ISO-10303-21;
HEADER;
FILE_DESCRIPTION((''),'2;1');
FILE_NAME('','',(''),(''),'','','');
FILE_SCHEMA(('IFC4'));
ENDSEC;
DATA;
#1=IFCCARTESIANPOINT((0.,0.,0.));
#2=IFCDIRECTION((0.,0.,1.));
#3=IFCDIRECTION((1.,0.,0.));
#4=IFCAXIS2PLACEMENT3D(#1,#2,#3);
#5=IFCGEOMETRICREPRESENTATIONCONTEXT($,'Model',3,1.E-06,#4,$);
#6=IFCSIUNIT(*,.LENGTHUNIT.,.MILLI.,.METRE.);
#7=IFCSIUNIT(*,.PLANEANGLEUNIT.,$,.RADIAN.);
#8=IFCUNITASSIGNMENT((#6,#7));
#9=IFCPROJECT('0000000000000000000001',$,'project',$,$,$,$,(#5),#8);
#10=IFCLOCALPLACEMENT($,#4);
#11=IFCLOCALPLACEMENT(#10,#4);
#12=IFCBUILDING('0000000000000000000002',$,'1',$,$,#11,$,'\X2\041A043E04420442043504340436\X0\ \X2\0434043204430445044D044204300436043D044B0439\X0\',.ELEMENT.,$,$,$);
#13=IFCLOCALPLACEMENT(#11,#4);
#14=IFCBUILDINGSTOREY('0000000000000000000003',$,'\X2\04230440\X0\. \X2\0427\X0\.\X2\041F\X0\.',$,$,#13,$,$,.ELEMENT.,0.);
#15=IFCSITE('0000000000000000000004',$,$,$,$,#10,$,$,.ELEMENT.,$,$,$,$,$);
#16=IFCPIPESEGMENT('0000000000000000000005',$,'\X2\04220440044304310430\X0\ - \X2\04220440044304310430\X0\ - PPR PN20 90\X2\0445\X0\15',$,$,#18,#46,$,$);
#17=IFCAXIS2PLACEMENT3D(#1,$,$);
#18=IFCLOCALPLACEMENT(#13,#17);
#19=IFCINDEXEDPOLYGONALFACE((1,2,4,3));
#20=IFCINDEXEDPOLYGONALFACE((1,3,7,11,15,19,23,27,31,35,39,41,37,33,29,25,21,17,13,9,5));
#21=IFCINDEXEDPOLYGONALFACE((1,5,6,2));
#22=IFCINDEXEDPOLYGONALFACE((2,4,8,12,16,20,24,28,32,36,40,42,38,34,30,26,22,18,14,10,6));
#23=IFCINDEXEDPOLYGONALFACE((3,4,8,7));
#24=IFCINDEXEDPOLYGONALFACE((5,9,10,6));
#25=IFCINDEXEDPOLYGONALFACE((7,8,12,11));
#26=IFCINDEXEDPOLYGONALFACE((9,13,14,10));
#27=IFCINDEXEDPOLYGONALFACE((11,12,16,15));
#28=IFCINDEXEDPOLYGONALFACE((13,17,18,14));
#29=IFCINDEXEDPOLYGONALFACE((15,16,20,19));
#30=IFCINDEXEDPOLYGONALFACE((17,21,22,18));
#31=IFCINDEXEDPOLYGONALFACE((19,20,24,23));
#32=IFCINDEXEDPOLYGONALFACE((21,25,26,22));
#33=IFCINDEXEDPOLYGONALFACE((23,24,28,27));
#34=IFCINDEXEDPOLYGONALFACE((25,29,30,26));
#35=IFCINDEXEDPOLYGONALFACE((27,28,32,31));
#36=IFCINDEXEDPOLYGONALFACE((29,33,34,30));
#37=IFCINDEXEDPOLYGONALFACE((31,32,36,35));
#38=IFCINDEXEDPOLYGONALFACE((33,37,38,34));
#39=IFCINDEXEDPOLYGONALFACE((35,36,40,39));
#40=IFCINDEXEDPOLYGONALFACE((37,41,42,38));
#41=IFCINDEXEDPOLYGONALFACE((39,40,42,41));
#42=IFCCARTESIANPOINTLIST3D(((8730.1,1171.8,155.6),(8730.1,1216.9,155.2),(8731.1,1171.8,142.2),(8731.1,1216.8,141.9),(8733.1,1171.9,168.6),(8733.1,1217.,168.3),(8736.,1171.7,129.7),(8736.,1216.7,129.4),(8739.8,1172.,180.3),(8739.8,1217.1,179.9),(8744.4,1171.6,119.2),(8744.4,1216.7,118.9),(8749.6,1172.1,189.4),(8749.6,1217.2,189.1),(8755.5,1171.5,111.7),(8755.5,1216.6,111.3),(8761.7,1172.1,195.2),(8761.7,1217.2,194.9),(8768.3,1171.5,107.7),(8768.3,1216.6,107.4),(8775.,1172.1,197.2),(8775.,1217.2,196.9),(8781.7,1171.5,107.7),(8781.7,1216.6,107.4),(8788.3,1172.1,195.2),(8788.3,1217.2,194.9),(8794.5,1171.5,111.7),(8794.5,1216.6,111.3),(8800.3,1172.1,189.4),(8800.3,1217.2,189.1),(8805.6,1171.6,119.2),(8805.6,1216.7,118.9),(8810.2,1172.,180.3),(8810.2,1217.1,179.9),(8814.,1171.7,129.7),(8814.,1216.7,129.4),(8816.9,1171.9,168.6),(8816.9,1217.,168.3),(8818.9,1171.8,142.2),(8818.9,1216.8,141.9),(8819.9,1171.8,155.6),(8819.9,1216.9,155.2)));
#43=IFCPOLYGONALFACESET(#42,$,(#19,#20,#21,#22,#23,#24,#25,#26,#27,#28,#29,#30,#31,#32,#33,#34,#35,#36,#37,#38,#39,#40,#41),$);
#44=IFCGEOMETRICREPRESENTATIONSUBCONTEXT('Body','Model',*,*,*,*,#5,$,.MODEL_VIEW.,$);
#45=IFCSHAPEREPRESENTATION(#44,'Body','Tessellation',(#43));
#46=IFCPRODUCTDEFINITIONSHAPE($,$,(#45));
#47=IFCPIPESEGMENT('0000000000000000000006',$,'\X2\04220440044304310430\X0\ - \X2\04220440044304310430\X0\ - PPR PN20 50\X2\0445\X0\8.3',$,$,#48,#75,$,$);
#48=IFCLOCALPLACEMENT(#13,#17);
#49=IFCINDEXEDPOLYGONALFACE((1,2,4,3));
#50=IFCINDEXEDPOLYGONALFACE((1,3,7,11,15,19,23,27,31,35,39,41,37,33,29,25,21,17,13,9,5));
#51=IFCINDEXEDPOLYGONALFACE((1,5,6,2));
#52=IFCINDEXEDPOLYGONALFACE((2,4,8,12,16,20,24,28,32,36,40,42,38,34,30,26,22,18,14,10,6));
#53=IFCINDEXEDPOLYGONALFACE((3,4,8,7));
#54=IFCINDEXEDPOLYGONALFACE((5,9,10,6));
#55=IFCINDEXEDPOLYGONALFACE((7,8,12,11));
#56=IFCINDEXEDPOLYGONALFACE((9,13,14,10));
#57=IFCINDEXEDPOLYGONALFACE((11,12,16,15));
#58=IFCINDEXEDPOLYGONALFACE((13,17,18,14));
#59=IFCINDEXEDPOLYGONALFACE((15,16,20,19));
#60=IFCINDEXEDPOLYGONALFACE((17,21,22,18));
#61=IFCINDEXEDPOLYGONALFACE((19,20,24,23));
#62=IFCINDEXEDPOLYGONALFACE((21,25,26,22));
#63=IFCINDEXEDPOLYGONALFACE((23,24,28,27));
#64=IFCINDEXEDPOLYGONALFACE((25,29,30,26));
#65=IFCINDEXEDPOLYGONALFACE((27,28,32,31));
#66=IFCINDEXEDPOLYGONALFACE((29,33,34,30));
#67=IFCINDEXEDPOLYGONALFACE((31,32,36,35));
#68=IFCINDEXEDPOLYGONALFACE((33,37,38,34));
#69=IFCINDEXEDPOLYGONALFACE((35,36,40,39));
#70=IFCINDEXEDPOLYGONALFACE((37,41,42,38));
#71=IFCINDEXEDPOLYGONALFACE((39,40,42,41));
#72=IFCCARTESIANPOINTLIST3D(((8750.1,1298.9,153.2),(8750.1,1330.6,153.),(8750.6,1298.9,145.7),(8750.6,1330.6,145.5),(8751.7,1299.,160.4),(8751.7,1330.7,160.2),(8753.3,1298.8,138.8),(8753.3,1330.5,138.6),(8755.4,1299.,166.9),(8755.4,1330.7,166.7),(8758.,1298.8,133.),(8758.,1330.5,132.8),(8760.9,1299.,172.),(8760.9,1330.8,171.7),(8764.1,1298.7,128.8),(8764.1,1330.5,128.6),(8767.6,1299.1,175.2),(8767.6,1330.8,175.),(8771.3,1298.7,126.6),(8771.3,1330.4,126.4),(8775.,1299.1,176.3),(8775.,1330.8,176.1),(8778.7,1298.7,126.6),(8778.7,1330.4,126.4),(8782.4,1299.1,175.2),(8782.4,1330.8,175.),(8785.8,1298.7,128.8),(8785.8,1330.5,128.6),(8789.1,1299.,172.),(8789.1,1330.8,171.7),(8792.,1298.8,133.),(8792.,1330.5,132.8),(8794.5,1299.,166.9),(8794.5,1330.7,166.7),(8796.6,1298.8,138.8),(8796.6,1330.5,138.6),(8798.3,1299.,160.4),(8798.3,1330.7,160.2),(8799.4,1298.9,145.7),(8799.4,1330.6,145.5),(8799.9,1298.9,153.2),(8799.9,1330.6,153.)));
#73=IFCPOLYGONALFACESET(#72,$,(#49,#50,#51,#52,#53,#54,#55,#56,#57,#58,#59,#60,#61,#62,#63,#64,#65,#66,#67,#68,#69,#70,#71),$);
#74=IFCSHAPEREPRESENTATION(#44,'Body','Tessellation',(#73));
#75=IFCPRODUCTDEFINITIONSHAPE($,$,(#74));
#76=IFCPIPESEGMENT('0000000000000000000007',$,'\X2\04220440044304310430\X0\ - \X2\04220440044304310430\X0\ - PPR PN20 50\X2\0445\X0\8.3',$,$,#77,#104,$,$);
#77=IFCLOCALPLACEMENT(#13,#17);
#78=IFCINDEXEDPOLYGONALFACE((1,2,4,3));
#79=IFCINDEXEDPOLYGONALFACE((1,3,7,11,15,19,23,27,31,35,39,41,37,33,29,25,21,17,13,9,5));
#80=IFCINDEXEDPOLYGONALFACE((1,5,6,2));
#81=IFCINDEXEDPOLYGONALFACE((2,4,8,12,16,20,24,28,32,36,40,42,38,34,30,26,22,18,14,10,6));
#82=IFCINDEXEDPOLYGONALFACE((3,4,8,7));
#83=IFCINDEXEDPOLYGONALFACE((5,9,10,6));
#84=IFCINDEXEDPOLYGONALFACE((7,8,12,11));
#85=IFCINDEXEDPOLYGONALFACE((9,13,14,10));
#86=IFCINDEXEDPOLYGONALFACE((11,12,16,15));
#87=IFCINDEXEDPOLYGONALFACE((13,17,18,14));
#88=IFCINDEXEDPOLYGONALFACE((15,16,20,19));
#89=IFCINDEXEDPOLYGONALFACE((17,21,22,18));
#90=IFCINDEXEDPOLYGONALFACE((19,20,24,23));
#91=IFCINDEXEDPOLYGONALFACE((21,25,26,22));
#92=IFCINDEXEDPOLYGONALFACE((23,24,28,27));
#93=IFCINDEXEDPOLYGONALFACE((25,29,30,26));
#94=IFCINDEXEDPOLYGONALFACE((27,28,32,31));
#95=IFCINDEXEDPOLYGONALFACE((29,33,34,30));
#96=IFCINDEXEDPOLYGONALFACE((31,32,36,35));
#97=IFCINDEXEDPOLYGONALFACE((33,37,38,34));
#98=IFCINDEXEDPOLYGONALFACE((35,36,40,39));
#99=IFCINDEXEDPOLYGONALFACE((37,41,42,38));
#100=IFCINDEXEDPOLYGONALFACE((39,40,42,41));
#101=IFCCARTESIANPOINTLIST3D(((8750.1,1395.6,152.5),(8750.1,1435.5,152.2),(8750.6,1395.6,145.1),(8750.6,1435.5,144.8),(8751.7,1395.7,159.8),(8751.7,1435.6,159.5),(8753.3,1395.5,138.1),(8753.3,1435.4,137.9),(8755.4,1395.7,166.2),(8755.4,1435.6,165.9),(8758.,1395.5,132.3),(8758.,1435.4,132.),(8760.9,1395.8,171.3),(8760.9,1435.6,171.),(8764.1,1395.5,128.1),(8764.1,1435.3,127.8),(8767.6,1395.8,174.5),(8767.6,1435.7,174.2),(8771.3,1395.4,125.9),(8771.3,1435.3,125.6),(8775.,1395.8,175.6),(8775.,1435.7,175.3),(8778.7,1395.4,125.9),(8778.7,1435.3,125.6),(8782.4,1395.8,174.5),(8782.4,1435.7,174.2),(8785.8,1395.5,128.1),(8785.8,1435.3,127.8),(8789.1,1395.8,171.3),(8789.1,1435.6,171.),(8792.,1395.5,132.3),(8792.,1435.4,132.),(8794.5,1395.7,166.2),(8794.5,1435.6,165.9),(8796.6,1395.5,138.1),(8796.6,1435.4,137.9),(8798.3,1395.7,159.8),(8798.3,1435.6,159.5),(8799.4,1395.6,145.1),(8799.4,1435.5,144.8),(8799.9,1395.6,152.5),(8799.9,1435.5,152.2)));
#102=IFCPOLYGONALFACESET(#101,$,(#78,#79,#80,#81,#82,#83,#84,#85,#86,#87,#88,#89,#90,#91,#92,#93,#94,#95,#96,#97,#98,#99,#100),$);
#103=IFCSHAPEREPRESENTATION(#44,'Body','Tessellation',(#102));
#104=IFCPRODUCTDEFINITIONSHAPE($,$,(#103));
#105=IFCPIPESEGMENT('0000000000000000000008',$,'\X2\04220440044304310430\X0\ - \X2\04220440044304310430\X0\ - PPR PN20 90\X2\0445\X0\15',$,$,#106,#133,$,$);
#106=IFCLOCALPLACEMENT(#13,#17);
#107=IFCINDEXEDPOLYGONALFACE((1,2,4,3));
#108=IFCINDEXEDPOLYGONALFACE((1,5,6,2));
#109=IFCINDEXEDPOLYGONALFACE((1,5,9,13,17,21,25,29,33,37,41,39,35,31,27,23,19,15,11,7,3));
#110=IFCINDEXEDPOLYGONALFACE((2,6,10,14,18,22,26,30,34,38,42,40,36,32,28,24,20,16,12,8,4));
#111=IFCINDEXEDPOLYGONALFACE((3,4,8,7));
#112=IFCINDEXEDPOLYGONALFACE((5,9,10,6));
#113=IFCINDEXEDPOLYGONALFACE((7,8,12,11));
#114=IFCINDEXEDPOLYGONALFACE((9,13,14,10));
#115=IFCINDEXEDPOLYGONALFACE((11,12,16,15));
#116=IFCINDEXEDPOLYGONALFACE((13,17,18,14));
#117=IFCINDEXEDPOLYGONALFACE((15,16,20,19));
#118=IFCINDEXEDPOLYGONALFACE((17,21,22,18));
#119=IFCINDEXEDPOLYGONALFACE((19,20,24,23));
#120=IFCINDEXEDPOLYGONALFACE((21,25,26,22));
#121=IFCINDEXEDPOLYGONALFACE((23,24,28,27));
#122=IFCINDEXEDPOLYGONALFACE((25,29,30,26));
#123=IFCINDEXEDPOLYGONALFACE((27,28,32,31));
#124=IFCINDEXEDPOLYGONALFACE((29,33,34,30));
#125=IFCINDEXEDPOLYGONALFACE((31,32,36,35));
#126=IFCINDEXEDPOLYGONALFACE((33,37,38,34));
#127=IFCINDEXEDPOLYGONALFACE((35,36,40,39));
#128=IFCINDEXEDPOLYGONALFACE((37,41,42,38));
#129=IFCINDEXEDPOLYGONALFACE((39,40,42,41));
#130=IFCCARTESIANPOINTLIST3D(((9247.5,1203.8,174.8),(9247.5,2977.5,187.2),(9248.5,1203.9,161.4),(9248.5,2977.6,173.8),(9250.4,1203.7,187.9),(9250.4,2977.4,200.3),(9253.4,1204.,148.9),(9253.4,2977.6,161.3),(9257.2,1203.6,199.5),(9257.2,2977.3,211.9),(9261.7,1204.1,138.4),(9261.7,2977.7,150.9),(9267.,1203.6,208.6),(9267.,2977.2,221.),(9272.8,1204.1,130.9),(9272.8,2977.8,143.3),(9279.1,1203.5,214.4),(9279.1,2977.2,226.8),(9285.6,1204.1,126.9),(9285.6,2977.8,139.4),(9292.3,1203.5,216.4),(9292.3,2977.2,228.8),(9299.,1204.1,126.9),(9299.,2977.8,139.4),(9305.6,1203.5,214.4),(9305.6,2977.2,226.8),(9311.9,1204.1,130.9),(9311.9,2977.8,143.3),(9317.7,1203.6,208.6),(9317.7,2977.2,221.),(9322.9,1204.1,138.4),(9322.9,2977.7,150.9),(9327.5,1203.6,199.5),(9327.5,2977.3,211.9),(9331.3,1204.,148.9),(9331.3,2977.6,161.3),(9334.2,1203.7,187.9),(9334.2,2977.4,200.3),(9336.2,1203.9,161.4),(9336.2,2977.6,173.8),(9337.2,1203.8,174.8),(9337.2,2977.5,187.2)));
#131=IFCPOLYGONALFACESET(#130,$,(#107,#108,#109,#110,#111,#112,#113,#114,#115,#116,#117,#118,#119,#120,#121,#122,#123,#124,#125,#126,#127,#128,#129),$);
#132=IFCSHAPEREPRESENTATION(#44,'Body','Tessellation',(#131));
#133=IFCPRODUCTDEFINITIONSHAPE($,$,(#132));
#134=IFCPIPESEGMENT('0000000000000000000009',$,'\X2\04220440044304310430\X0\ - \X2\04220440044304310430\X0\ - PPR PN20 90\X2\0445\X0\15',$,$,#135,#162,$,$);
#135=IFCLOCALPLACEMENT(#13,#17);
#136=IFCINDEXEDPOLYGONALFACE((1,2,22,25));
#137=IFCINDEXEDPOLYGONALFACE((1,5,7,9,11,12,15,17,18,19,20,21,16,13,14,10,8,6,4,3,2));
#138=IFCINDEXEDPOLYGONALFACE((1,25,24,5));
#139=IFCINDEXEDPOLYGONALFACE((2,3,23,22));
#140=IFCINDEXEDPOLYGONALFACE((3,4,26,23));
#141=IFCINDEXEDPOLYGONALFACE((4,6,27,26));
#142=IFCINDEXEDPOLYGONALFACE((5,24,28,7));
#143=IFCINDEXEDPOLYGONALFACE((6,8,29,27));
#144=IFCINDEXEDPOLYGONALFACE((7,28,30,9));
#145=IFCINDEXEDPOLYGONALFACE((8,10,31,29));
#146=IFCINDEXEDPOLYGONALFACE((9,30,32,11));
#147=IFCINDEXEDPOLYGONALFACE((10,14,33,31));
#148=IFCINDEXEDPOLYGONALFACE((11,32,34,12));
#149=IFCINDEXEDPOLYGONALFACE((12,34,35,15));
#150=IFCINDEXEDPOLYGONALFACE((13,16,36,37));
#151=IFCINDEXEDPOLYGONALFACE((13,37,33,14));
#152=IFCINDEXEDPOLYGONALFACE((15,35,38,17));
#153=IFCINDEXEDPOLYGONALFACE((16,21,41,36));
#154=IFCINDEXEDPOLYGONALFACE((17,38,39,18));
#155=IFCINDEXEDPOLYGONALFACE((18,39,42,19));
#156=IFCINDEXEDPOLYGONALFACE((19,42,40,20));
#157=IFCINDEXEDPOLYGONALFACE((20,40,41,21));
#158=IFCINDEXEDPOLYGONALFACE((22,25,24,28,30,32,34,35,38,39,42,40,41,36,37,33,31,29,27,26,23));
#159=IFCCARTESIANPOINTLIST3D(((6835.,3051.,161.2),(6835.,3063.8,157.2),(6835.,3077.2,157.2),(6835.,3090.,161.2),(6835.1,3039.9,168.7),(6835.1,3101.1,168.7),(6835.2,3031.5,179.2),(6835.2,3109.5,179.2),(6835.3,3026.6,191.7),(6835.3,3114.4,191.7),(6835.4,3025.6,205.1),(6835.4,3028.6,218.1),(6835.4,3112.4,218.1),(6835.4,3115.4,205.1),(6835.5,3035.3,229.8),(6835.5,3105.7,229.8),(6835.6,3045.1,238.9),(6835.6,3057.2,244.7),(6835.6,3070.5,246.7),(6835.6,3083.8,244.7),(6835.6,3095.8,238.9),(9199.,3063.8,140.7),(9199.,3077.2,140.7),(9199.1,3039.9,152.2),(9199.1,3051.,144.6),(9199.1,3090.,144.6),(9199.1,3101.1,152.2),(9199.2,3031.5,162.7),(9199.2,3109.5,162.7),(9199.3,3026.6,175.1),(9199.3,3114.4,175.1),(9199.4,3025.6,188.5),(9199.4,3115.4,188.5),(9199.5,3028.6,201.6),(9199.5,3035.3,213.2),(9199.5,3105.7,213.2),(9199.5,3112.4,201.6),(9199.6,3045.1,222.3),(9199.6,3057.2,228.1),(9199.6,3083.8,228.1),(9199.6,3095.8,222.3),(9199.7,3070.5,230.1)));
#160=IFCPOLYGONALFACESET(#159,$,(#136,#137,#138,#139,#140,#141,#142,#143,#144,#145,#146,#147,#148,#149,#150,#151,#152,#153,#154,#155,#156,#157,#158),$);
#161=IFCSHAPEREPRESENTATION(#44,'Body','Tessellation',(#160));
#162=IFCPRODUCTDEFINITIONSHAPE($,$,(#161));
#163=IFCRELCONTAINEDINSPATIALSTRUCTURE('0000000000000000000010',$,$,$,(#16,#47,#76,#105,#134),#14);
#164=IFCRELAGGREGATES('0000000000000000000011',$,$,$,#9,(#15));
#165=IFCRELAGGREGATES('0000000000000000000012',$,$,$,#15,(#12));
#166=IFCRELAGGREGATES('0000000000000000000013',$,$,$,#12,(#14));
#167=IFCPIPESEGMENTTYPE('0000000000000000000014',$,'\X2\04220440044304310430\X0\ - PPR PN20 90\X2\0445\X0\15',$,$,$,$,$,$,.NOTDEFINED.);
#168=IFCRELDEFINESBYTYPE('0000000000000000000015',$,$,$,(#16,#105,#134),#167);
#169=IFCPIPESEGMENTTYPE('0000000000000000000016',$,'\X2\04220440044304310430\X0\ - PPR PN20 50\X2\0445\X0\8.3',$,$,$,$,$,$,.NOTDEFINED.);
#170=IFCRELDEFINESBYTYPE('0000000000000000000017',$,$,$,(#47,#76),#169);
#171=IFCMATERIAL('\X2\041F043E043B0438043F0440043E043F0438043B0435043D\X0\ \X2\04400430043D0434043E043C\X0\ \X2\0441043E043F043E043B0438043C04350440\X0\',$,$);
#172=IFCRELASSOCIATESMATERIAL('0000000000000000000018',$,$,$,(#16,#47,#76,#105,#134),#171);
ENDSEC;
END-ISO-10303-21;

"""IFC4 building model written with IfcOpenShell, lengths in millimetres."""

from ifc_helpers import new_model, entity, si_unit, frame, origin_with_axes, place, context, subcontext, project, spatial, source, transform, mapped, material, type_object, element, save


model = new_model("IFC4")

# Units and contexts
model_context = context("Model", 3, precision=1e-06, world=origin_with_axes())
body_context = subcontext(model_context, "Body", "Model", "MODEL_VIEW")
ifc_project = project(units=[si_unit("LENGTHUNIT", "METRE", prefix="MILLI"), si_unit("PLANEANGLEUNIT", "RADIAN")], contexts=[model_context])

# Site, building, storey
site_placement = place(None, origin_with_axes())
site = spatial("IfcSite", under=ifc_project, at=site_placement, CompositionType="ELEMENT")
building_placement = place(site_placement, origin_with_axes())
building = spatial("IfcBuilding", under=site, at=building_placement, Name="1", LongName="Коттедж двухэтажный", CompositionType="ELEMENT")
storey_placement = place(building_placement, origin_with_axes())
storey = spatial("IfcBuildingStorey", under=building, at=storey_placement, Name="Ур. Ч.П.", CompositionType="ELEMENT", Elevation=0.0)

# Pipe segments
ifc_material = material(Name="Полипропилен рандом сополимер")
pipe_segment_type_1 = type_object("IfcPipeSegmentType", Name="Труба - PPR PN20 90х15", PredefinedType="NOTDEFINED")
pipe_segment_type_2 = type_object("IfcPipeSegmentType", Name="Труба - PPR PN20 50х8.3", PredefinedType="NOTDEFINED")
shared_shape_1 = source(origin_with_axes(), body_context, "Body", "AdvancedSweptSolid", [
    entity("IfcSweptDiskSolid", entity("IfcIndexedPolyCurve", entity("IfcCartesianPointList3D", [[0.0, 0.0, 0.0], [45.1, 0.0, 0.3]]), [entity("IfcLineIndex", [1, 2])]), 45.0),
])
pipe_segment_1_placement = place(storey_placement, frame((8775.0, 1216.9, 151.9), z_axis=(0.0, 0.0, 1.0), x_axis=(0.0, -1.0, 0.0)))
element("IfcPipeSegment", 1, at=pipe_segment_1_placement, inside=storey, type_object=pipe_segment_type_1, material=ifc_material, Name="Труба - Труба - PPR PN20 90х15", context=body_context, shape_type="MappedRepresentation", body=[
    mapped(shared_shape_1, transform((0.0, 0.0, 0.0), x_axis=(1.0, 0.0, 0.0), y_axis=(0.0, 1.0, 0.0), z_axis=(0.0, 0.0, 1.0), scale=1.0)),
])
shared_shape_2 = source(origin_with_axes(), body_context, "Body", "AdvancedSweptSolid", [
    entity("IfcSweptDiskSolid", entity("IfcIndexedPolyCurve", entity("IfcCartesianPointList3D", [[0.0, 0.0, 0.0], [31.7, 0.0, 0.2]]), [entity("IfcLineIndex", [1, 2])]), 25.0),
])
pipe_segment_2_placement = place(storey_placement, frame((8775.0, 1330.6, 151.1), z_axis=(0.0, 0.0, 1.0), x_axis=(0.0, -1.0, 0.0)))
element("IfcPipeSegment", 2, at=pipe_segment_2_placement, inside=storey, type_object=pipe_segment_type_2, material=ifc_material, Name="Труба - Труба - PPR PN20 50х8.3", context=body_context, shape_type="MappedRepresentation", body=[
    mapped(shared_shape_2, transform((0.0, 0.0, 0.0), x_axis=(1.0, 0.0, 0.0), y_axis=(0.0, 1.0, 0.0), z_axis=(0.0, 0.0, 1.0), scale=1.0)),
])
shared_shape_3 = source(origin_with_axes(), body_context, "Body", "AdvancedSweptSolid", [
    entity("IfcSweptDiskSolid", entity("IfcIndexedPolyCurve", entity("IfcCartesianPointList3D", [[0.0, 0.0, 0.0], [39.9, 0.0, 0.3]]), [entity("IfcLineIndex", [1, 2])]), 25.0),
])
pipe_segment_3_placement = place(storey_placement, frame((8775.0, 1435.5, 150.3), z_axis=(0.0, 0.0, 1.0), x_axis=(0.0, -1.0, 0.0)))
element("IfcPipeSegment", 3, at=pipe_segment_3_placement, inside=storey, type_object=pipe_segment_type_2, material=ifc_material, Name="Труба - Труба - PPR PN20 50х8.3", context=body_context, shape_type="MappedRepresentation", body=[
    mapped(shared_shape_3, transform((0.0, 0.0, 0.0), x_axis=(1.0, 0.0, 0.0), y_axis=(0.0, 1.0, 0.0), z_axis=(0.0, 0.0, 1.0), scale=1.0)),
])
shared_shape_4 = source(origin_with_axes(), body_context, "Body", "AdvancedSweptSolid", [
    entity("IfcSweptDiskSolid", entity("IfcIndexedPolyCurve", entity("IfcCartesianPointList3D", [[0.0, 0.0, 0.0], [1773.7, 0.0, 12.4]]), [entity("IfcLineIndex", [1, 2])]), 45.0),
])
pipe_segment_4_placement = place(storey_placement, frame((9292.3, 1203.8, 171.4), z_axis=(0.0, 0.0, 1.0), x_axis=(0.0, 1.0, 0.0)))
element("IfcPipeSegment", 4, at=pipe_segment_4_placement, inside=storey, type_object=pipe_segment_type_1, material=ifc_material, Name="Труба - Труба - PPR PN20 90х15", context=body_context, shape_type="MappedRepresentation", body=[
    mapped(shared_shape_4, transform((0.0, 0.0, 0.0), x_axis=(1.0, 0.0, 0.0), y_axis=(0.0, 1.0, 0.0), z_axis=(0.0, 0.0, 1.0), scale=1.0)),
])
shared_shape_5 = source(origin_with_axes(), body_context, "Body", "AdvancedSweptSolid", [
    entity("IfcSweptDiskSolid", entity("IfcIndexedPolyCurve", entity("IfcCartesianPointList3D", [[0.0, 0.0, 0.0], [2364.0, 0.0, 16.5]]), [entity("IfcLineIndex", [1, 2])]), 45.0),
])
pipe_segment_5_placement = place(storey_placement, frame((9199.3, 3070.5, 185.1), z_axis=(0.0, 0.0, 1.0), x_axis=(-1.0, 0.0, 0.0)))
element("IfcPipeSegment", 5, at=pipe_segment_5_placement, inside=storey, type_object=pipe_segment_type_1, material=ifc_material, Name="Труба - Труба - PPR PN20 90х15", context=body_context, shape_type="MappedRepresentation", body=[
    mapped(shared_shape_5, transform((0.0, 0.0, 0.0), x_axis=(1.0, 0.0, 0.0), y_axis=(0.0, 1.0, 0.0), z_axis=(0.0, 0.0, 1.0), scale=1.0)),
])

save(model, "model.ifc")
